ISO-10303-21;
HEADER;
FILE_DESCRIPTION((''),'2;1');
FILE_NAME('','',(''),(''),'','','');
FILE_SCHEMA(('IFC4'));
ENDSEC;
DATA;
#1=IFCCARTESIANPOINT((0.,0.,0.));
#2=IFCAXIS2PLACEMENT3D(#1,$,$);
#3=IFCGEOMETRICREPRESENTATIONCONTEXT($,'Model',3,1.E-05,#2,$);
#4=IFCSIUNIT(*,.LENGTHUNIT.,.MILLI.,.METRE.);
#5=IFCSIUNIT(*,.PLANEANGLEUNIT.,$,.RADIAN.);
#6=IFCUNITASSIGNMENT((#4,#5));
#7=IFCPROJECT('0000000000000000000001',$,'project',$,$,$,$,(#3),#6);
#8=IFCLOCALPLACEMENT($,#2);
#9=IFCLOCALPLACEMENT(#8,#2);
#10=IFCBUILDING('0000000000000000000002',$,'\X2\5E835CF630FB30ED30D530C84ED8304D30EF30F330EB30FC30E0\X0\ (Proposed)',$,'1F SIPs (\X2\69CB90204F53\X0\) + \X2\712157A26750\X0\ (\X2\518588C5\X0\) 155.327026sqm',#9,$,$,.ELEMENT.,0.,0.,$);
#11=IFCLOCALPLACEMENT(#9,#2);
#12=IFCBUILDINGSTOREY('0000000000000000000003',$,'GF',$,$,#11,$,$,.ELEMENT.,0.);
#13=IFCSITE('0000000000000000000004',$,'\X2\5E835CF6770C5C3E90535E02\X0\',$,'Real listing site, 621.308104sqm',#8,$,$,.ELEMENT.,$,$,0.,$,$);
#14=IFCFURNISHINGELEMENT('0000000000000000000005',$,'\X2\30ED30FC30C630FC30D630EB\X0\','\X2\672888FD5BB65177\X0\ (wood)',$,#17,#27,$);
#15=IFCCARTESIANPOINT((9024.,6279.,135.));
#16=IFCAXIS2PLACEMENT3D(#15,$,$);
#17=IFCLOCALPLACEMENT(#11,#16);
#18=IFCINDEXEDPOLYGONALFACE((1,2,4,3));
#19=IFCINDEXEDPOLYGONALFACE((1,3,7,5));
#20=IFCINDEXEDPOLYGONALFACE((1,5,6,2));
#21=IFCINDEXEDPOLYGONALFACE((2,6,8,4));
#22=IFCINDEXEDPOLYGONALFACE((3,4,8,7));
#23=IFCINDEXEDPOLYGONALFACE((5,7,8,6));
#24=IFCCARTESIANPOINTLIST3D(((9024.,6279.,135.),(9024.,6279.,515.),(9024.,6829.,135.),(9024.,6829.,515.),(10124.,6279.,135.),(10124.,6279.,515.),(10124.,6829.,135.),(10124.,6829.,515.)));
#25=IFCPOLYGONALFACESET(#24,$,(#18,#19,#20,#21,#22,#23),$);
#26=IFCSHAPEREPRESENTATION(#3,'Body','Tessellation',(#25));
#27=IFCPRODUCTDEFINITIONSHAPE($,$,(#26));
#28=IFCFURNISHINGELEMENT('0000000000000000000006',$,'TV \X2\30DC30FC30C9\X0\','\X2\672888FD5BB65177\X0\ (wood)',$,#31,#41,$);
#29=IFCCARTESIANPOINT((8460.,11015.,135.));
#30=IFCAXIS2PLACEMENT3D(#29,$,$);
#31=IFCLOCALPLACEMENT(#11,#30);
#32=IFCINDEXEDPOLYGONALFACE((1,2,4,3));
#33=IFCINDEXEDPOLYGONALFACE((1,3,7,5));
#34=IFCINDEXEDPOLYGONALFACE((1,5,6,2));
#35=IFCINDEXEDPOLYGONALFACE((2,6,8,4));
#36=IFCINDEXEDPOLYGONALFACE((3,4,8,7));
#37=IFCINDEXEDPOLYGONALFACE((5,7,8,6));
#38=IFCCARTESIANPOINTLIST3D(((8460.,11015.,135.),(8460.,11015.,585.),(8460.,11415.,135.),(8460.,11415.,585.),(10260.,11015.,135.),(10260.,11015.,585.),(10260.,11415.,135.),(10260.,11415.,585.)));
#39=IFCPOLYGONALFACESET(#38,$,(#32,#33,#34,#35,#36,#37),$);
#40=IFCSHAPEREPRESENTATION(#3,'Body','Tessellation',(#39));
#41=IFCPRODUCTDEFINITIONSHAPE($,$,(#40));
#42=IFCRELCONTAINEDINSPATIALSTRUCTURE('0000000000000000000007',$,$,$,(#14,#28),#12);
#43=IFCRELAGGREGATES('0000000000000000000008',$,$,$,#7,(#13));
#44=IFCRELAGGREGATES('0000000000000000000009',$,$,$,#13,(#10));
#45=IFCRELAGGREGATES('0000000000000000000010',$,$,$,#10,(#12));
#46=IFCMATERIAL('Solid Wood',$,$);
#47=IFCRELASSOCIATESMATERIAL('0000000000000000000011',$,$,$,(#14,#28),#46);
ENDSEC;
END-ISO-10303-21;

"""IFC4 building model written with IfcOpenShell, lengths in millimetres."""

from ifc_helpers import new_model, si_unit, frame, frame_2d, origin, place, context, project, spatial, rectangle, extrude, material, element, save


model = new_model("IFC4")

# Units and contexts
model_context = context("Model", 3, precision=1e-05, world=origin())
ifc_project = project(units=[si_unit("LENGTHUNIT", "METRE", prefix="MILLI"), si_unit("PLANEANGLEUNIT", "RADIAN")], contexts=[model_context])

# Site, building, storey
site_placement = place(None, origin())
site = spatial("IfcSite", under=ifc_project, at=site_placement, Name="広島県尾道市", ObjectType="Real listing site, 621.308104sqm", CompositionType="ELEMENT", RefElevation=0.0)
building_placement = place(site_placement, origin())
building = spatial("IfcBuilding", under=site, at=building_placement, Name="広島・ロフト付きワンルーム (Proposed)", ObjectType="1F SIPs (構造体) + 無垢材 (内装) 155.327026sqm", CompositionType="ELEMENT", ElevationOfRefHeight=0.0, ElevationOfTerrain=0.0)
storey_placement = place(building_placement, origin())
storey = spatial("IfcBuildingStorey", under=building, at=storey_placement, Name="GF", CompositionType="ELEMENT", Elevation=0.0)

# Shared definitions
ifc_material_1 = material(Name="Solid Wood")

# Furnishing elements
furnishing_1_placement = place(storey_placement, frame((9024.0, 6279.0, 135.0)))
element("IfcFurnishingElement", 1, at=furnishing_1_placement, inside=storey, material=ifc_material_1, Name="ローテーブル", Description="木製家具 (wood)", context=model_context, shape_type="SweptSolid", body=[
    extrude(rectangle(XDim=1100.0, YDim=550.0, at=frame_2d((550.0, 275.0))), frame((9024.0, 6279.0, 135.0)), (0.0, 0.0, 1.0), 380.0),
])
furnishing_2_placement = place(storey_placement, frame((8460.0, 11015.0, 135.0)))
element("IfcFurnishingElement", 2, at=furnishing_2_placement, inside=storey, material=ifc_material_1, Name="TV ボード", Description="木製家具 (wood)", context=model_context, shape_type="SweptSolid", body=[
    extrude(rectangle(XDim=1800.0, YDim=400.0, at=frame_2d((900.0, 200.0))), frame((8460.0, 11015.0, 135.0)), (0.0, 0.0, 1.0), 450.0),
])

save(model, "model.ifc")
